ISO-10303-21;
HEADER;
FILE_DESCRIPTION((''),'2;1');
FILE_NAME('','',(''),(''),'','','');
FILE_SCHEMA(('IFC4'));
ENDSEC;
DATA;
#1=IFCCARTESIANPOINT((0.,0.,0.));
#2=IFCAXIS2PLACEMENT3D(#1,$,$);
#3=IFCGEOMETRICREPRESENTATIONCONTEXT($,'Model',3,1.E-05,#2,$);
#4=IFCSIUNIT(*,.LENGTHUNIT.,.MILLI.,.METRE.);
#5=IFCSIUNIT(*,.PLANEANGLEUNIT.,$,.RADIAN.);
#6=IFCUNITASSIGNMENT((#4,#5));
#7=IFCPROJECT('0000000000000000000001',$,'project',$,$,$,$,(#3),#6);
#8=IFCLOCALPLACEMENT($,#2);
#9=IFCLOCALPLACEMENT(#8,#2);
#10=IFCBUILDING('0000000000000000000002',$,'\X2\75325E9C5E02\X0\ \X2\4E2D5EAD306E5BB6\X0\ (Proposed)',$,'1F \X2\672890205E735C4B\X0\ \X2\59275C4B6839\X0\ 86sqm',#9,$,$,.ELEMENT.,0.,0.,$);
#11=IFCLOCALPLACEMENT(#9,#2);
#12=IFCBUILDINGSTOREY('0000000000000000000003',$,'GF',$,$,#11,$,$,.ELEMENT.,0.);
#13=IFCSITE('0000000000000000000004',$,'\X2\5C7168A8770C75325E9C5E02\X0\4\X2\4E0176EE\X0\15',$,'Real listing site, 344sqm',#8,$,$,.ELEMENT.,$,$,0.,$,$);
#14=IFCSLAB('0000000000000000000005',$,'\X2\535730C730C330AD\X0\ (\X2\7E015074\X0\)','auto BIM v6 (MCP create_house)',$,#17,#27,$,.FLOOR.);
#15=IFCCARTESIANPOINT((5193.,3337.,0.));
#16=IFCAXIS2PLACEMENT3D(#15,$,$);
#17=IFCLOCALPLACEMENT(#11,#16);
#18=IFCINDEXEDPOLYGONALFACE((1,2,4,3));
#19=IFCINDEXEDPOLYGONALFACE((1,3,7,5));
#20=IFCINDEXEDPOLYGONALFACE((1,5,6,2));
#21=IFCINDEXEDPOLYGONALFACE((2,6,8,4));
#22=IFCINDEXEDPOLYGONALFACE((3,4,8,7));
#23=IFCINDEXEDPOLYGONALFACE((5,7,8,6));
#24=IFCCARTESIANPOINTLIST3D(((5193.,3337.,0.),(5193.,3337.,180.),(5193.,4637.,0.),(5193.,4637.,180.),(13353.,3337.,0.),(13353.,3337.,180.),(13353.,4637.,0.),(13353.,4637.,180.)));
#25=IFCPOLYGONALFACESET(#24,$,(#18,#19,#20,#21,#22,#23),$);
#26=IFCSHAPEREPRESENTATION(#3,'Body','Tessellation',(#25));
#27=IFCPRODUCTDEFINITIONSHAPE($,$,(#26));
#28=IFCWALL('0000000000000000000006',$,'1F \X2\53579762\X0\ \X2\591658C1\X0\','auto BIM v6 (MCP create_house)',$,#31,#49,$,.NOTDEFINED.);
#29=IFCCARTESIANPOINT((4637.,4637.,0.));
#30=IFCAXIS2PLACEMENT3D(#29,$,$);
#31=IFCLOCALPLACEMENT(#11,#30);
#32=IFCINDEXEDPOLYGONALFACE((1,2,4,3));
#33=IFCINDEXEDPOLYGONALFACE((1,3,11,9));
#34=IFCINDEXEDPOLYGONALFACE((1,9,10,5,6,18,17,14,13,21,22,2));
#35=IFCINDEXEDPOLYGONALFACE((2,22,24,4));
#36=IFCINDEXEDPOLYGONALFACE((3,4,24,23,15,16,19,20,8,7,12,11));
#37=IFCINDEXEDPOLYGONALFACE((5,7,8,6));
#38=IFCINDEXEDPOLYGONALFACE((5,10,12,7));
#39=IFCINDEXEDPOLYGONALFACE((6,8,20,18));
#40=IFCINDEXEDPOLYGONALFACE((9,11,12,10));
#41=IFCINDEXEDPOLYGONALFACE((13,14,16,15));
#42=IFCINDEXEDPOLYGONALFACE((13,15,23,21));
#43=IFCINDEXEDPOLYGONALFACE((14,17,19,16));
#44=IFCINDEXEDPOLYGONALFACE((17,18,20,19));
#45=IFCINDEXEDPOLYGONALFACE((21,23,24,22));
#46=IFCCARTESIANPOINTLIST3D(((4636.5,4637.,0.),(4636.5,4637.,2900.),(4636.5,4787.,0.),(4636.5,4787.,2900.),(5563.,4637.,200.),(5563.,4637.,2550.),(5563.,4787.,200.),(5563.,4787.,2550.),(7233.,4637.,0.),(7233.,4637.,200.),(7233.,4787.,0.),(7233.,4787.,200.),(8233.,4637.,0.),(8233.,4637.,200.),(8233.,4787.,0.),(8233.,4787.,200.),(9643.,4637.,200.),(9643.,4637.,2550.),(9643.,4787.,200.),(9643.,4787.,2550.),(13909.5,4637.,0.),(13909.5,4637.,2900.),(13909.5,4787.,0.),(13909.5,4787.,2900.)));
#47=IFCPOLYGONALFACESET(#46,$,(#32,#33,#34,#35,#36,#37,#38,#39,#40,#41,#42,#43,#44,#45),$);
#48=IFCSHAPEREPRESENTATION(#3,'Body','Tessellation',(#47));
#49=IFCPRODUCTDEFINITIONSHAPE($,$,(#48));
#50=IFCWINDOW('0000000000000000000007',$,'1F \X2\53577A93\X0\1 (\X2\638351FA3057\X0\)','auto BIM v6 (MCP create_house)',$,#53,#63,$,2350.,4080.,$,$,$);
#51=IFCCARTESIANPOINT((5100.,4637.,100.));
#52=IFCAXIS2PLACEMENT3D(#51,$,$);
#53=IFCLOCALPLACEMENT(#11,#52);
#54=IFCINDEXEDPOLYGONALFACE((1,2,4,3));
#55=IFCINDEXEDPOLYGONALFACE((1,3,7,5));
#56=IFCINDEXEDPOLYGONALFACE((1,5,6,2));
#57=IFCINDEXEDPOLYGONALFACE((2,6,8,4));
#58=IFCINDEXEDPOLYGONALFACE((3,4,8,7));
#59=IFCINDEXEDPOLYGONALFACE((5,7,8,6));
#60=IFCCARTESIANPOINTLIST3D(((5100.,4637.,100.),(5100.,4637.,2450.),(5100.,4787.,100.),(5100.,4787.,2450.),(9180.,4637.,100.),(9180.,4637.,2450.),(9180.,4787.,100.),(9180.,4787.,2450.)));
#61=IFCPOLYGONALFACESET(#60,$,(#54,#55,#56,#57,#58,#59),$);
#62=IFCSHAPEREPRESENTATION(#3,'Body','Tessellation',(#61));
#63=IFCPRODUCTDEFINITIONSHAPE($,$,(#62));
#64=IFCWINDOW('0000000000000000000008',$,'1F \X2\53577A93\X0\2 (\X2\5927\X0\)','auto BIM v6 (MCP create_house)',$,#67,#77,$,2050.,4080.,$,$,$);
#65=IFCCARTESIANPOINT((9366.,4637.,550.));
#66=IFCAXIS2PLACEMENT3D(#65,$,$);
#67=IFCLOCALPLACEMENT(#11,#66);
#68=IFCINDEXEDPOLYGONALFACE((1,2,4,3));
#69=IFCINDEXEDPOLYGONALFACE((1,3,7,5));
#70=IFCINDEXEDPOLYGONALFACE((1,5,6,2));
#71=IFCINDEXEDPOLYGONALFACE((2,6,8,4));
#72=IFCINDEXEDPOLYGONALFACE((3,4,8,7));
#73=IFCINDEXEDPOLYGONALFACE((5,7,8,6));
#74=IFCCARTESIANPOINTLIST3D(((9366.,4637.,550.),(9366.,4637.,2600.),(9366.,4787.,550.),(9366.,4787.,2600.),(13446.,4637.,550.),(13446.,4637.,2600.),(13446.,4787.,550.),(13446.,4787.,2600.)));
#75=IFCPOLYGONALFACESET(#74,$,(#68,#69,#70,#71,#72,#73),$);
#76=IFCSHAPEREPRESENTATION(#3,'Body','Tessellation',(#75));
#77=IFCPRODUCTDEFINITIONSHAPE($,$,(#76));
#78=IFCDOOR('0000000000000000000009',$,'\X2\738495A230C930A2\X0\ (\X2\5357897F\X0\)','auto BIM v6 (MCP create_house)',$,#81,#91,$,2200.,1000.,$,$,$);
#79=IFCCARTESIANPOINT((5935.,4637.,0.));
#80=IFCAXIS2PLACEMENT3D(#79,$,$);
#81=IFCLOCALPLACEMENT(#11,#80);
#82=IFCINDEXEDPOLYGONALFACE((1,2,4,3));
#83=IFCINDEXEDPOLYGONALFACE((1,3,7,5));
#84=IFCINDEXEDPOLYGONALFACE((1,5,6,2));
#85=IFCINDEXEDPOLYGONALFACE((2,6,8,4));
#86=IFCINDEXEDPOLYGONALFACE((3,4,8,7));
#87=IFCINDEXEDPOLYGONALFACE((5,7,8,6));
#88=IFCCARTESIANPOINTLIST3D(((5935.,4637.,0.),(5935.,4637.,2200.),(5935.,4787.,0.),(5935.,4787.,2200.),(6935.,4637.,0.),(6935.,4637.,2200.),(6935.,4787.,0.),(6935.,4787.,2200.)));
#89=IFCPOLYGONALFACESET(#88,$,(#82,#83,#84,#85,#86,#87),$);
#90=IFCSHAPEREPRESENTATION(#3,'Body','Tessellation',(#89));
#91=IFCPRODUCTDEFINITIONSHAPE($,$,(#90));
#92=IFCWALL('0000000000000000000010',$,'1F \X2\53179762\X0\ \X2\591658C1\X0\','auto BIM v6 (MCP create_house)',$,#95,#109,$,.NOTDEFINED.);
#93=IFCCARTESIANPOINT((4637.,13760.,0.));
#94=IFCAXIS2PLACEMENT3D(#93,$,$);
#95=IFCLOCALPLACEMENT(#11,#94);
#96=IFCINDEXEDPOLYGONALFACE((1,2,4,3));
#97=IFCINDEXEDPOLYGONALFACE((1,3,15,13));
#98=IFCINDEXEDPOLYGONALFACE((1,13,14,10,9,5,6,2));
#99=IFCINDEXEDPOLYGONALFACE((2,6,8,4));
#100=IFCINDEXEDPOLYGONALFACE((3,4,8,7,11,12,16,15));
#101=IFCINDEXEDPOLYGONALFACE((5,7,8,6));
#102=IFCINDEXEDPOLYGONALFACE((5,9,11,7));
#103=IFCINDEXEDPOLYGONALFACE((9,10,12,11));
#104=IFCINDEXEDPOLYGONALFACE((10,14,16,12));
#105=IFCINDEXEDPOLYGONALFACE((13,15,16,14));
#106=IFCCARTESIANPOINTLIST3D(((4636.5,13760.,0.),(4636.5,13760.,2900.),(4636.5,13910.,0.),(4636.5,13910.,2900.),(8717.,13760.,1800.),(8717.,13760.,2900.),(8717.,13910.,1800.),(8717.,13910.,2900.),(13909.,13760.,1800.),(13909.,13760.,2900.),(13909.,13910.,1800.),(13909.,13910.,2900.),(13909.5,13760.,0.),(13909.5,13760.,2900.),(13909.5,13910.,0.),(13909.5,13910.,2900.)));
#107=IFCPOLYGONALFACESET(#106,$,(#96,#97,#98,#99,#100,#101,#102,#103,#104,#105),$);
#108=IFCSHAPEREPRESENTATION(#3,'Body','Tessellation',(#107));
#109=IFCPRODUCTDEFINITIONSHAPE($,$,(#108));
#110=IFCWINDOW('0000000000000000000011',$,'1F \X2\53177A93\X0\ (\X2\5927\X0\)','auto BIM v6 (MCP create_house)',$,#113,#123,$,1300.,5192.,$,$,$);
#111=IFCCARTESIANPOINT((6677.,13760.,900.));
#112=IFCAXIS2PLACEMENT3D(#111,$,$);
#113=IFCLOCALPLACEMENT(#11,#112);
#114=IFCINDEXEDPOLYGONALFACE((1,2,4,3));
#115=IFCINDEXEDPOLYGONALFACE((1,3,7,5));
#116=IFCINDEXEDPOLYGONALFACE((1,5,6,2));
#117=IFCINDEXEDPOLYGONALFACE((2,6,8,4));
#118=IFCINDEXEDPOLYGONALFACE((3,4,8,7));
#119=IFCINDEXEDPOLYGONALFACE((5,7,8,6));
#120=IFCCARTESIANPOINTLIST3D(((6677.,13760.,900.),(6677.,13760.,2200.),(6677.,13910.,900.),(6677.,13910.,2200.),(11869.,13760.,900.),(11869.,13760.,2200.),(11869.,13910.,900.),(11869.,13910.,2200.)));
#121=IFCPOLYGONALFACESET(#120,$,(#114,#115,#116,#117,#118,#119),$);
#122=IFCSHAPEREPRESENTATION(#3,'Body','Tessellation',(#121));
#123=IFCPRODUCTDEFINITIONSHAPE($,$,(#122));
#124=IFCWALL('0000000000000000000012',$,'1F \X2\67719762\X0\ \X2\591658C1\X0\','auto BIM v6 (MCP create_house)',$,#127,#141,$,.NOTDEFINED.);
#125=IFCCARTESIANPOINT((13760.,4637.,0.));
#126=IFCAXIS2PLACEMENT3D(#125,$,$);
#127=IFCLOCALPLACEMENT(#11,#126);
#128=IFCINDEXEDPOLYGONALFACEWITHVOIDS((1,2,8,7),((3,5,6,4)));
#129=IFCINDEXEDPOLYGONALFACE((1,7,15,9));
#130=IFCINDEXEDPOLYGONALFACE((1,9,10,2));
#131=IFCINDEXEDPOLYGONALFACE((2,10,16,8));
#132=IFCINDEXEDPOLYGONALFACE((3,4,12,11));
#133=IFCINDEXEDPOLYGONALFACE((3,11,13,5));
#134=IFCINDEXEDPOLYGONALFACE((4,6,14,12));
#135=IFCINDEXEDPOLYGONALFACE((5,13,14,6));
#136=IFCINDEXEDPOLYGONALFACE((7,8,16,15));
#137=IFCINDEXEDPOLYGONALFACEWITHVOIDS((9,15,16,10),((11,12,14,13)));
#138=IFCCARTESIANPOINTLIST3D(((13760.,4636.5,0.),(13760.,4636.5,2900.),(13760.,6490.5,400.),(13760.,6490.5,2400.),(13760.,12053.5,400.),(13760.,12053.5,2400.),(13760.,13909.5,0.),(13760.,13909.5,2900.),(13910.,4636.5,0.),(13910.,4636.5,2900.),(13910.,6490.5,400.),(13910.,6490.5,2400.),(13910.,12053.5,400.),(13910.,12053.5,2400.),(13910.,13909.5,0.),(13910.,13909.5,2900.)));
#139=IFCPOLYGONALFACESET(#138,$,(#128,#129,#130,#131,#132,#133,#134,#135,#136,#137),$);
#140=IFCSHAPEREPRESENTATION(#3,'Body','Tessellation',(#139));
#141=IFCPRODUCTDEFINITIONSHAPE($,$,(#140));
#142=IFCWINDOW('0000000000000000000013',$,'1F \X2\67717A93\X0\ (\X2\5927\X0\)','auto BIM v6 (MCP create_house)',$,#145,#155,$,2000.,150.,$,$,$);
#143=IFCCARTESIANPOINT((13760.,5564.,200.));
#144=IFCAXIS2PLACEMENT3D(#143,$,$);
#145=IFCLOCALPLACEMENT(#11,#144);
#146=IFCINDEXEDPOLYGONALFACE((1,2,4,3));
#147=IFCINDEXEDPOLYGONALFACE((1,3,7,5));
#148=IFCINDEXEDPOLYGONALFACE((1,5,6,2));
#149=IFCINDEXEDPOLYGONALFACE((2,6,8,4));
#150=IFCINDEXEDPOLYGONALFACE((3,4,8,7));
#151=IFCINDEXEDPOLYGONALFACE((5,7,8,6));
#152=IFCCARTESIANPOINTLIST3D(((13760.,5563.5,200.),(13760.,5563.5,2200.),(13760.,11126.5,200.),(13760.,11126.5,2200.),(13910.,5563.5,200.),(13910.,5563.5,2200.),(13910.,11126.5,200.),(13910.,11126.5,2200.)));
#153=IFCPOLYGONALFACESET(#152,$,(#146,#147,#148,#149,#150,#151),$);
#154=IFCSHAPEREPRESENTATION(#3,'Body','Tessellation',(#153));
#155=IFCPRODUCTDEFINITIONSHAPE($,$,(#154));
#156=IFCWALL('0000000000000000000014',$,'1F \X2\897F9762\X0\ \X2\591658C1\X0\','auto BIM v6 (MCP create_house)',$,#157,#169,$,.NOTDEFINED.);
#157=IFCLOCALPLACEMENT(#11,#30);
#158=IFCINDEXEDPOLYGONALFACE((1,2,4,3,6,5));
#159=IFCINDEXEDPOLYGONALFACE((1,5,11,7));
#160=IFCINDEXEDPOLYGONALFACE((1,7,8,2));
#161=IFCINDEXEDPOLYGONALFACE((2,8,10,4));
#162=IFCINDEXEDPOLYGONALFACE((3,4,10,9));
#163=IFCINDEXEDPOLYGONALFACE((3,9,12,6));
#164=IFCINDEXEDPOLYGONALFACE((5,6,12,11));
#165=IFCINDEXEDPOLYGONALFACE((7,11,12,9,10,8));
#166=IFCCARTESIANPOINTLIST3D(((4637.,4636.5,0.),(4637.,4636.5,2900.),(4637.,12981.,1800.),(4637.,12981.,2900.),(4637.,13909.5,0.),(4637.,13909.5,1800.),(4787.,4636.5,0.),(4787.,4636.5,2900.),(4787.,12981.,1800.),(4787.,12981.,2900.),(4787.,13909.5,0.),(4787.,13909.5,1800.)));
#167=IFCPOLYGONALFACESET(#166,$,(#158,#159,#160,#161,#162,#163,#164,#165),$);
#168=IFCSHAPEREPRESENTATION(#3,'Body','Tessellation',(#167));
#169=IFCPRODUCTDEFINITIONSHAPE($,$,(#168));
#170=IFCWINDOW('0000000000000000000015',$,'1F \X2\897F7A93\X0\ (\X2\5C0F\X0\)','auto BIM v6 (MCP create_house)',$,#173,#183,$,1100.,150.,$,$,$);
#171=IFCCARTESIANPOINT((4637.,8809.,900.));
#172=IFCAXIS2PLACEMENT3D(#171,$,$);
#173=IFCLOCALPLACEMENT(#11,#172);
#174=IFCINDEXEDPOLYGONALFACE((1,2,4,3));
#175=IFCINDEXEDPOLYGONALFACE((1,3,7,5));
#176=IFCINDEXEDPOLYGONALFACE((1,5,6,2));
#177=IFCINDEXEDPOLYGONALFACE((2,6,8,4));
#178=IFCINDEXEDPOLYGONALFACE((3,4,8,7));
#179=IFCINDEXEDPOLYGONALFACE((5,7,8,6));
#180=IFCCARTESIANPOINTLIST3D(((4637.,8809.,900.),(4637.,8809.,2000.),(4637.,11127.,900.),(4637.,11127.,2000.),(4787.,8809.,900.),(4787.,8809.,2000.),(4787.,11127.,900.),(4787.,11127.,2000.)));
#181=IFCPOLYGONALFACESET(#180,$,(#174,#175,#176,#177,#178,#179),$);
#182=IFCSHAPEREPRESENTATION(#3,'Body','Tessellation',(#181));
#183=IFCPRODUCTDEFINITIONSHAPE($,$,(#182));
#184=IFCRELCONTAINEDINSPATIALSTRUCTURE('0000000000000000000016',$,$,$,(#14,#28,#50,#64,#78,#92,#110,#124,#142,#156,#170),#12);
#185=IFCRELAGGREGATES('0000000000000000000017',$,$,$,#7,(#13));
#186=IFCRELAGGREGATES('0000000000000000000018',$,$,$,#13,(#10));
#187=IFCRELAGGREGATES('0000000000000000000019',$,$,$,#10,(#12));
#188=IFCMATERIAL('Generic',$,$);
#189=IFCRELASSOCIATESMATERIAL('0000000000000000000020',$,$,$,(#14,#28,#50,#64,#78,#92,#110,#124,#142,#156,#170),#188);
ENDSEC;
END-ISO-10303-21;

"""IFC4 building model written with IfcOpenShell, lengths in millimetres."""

from ifc_helpers import new_model, si_unit, frame, frame_2d, origin, place, context, project, spatial, rectangle, extrude, material, element, fill, save


model = new_model("IFC4")

# Units and contexts
model_context = context("Model", 3, precision=1e-05, world=origin())
ifc_project = project(units=[si_unit("LENGTHUNIT", "METRE", prefix="MILLI"), si_unit("PLANEANGLEUNIT", "RADIAN")], contexts=[model_context])

# Site, building, storey
site_placement = place(None, origin())
site = spatial("IfcSite", under=ifc_project, at=site_placement, Name="山梨県甲府市4丁目15", ObjectType="Real listing site, 344sqm", CompositionType="ELEMENT", RefElevation=0.0)
building_placement = place(site_placement, origin())
building = spatial("IfcBuilding", under=site, at=building_placement, Name="甲府市 中庭の家 (Proposed)", ObjectType="1F 木造平屋 大屋根 86sqm", CompositionType="ELEMENT", ElevationOfRefHeight=0.0, ElevationOfTerrain=0.0)
storey_placement = place(building_placement, origin())
storey = spatial("IfcBuildingStorey", under=building, at=storey_placement, Name="GF", CompositionType="ELEMENT", Elevation=0.0)

# Slab
ifc_material = material(Name="Generic")
slab_1_placement = place(storey_placement, frame((5193.0, 3337.0, 0.0)))
element("IfcSlab", 1, at=slab_1_placement, inside=storey, material=ifc_material, Name="南デッキ (縁側)", Description="auto BIM v6 (MCP create_house)", PredefinedType="FLOOR", context=model_context, shape_type="SweptSolid", body=[
    extrude(rectangle(XDim=8160.0, YDim=1300.0, at=frame_2d((4080.0, 650.0))), frame((5193.0, 3337.0, 0.0)), (0.0, 0.0, 1.0), 180.0),
])

# Wall, openings, windows, door
wall_1_placement = place(storey_placement, frame((4637.0, 4637.0, 0.0)))
wall_1 = element("IfcWall", 2, at=wall_1_placement, inside=storey, material=ifc_material, Name="1F 南面 外壁", Description="auto BIM v6 (MCP create_house)", PredefinedType="NOTDEFINED", context=model_context, shape_type="SweptSolid", body=[
    extrude(rectangle(XDim=9273.0, YDim=150.0, at=frame_2d((4636.0, 75.0))), frame((4637.0, 4637.0, 0.0)), (0.0, 0.0, 1.0), 2900.0),
])
opening_1_placement = place(storey_placement, frame((5100.0, 4637.0, 100.0)))
opening_1 = element("IfcOpeningElement", 3, at=opening_1_placement, cuts=wall_1, PredefinedType="NOTDEFINED", context=model_context, shape_type="SweptSolid", body=[
    extrude(rectangle(XDim=4080.0, YDim=150.0, at=frame_2d((2040.0, 75.0))), frame((5100.0, 4637.0, 100.0)), (0.0, 0.0, 1.0), 2350.0),
])
opening_2_placement = place(storey_placement, frame((9366.0, 4637.0, 550.0)))
opening_2 = element("IfcOpeningElement", 4, at=opening_2_placement, cuts=wall_1, PredefinedType="NOTDEFINED", context=model_context, shape_type="SweptSolid", body=[
    extrude(rectangle(XDim=4080.0, YDim=150.0, at=frame_2d((2040.0, 75.0))), frame((9366.0, 4637.0, 550.0)), (0.0, 0.0, 1.0), 2050.0),
])
opening_3_placement = place(storey_placement, frame((5935.0, 4637.0, 0.0)))
opening_3 = element("IfcOpeningElement", 5, at=opening_3_placement, cuts=wall_1, PredefinedType="NOTDEFINED", context=model_context, shape_type="SweptSolid", body=[
    extrude(rectangle(XDim=1000.0, YDim=150.0, at=frame_2d((500.0, 75.0))), frame((5935.0, 4637.0, 0.0)), (0.0, 0.0, 1.0), 2200.0),
])
window_1_placement = place(storey_placement, frame((5100.0, 4637.0, 100.0)))
window_1 = element("IfcWindow", 6, at=window_1_placement, inside=storey, material=ifc_material, Name="1F 南窓1 (掃出し)", Description="auto BIM v6 (MCP create_house)", OverallHeight=2350.0, OverallWidth=4080.0, context=model_context, shape_type="SweptSolid", body=[
    extrude(rectangle(XDim=4080.0, YDim=150.0, at=frame_2d((2040.0, 75.0))), frame((5100.0, 4637.0, 100.0)), (0.0, 0.0, 1.0), 2350.0),
])
fill(opening_1, window_1)
window_2_placement = place(storey_placement, frame((9366.0, 4637.0, 550.0)))
window_2 = element("IfcWindow", 7, at=window_2_placement, inside=storey, material=ifc_material, Name="1F 南窓2 (大)", Description="auto BIM v6 (MCP create_house)", OverallHeight=2050.0, OverallWidth=4080.0, context=model_context, shape_type="SweptSolid", body=[
    extrude(rectangle(XDim=4080.0, YDim=150.0, at=frame_2d((2040.0, 75.0))), frame((9366.0, 4637.0, 550.0)), (0.0, 0.0, 1.0), 2050.0),
])
fill(opening_2, window_2)
door_placement = place(storey_placement, frame((5935.0, 4637.0, 0.0)))
door = element("IfcDoor", 8, at=door_placement, inside=storey, material=ifc_material, Name="玄関ドア (南西)", Description="auto BIM v6 (MCP create_house)", OverallHeight=2200.0, OverallWidth=1000.0, context=model_context, shape_type="SweptSolid", body=[
    extrude(rectangle(XDim=1000.0, YDim=150.0, at=frame_2d((500.0, 75.0))), frame((5935.0, 4637.0, 0.0)), (0.0, 0.0, 1.0), 2200.0),
])
fill(opening_3, door)

# Walls, openings, windows
wall_2_placement = place(storey_placement, frame((4637.0, 13760.0, 0.0)))
wall_2 = element("IfcWall", 9, at=wall_2_placement, inside=storey, material=ifc_material, Name="1F 北面 外壁", Description="auto BIM v6 (MCP create_house)", PredefinedType="NOTDEFINED", context=model_context, shape_type="SweptSolid", body=[
    extrude(rectangle(XDim=9273.0, YDim=150.0, at=frame_2d((4636.0, 75.0))), frame((4637.0, 13760.0, 0.0)), (0.0, 0.0, 1.0), 2900.0),
])
opening_4_placement = place(storey_placement, frame((6677.0, 13760.0, 900.0)))
opening_4 = element("IfcOpeningElement", 10, at=opening_4_placement, cuts=wall_2, PredefinedType="NOTDEFINED", context=model_context, shape_type="SweptSolid", body=[
    extrude(rectangle(XDim=5192.0, YDim=150.0, at=frame_2d((2596.0, 75.0))), frame((6677.0, 13760.0, 900.0)), (0.0, 0.0, 1.0), 1300.0),
])
window_3_placement = place(storey_placement, frame((6677.0, 13760.0, 900.0)))
window_3 = element("IfcWindow", 11, at=window_3_placement, inside=storey, material=ifc_material, Name="1F 北窓 (大)", Description="auto BIM v6 (MCP create_house)", OverallHeight=1300.0, OverallWidth=5192.0, context=model_context, shape_type="SweptSolid", body=[
    extrude(rectangle(XDim=5192.0, YDim=150.0, at=frame_2d((2596.0, 75.0))), frame((6677.0, 13760.0, 900.0)), (0.0, 0.0, 1.0), 1300.0),
])
fill(opening_4, window_3)
wall_3_placement = place(storey_placement, frame((13760.0, 4637.0, 0.0)))
wall_3 = element("IfcWall", 12, at=wall_3_placement, inside=storey, material=ifc_material, Name="1F 東面 外壁", Description="auto BIM v6 (MCP create_house)", PredefinedType="NOTDEFINED", context=model_context, shape_type="SweptSolid", body=[
    extrude(rectangle(XDim=150.0, YDim=9273.0, at=frame_2d((75.0, 4636.0))), frame((13760.0, 4637.0, 0.0)), (0.0, 0.0, 1.0), 2900.0),
])
opening_5_placement = place(storey_placement, frame((13760.0, 5564.0, 200.0)))
opening_5 = element("IfcOpeningElement", 13, at=opening_5_placement, cuts=wall_3, PredefinedType="NOTDEFINED", context=model_context, shape_type="SweptSolid", body=[
    extrude(rectangle(XDim=150.0, YDim=5563.0, at=frame_2d((75.0, 2781.0))), frame((13760.0, 5564.0, 200.0)), (0.0, 0.0, 1.0), 2000.0),
])
window_4_placement = place(storey_placement, frame((13760.0, 5564.0, 200.0)))
window_4 = element("IfcWindow", 14, at=window_4_placement, inside=storey, material=ifc_material, Name="1F 東窓 (大)", Description="auto BIM v6 (MCP create_house)", OverallHeight=2000.0, OverallWidth=150.0, context=model_context, shape_type="SweptSolid", body=[
    extrude(rectangle(XDim=150.0, YDim=5563.0, at=frame_2d((75.0, 2781.0))), frame((13760.0, 5564.0, 200.0)), (0.0, 0.0, 1.0), 2000.0),
])
fill(opening_5, window_4)
wall_4_placement = place(storey_placement, frame((4637.0, 4637.0, 0.0)))
wall_4 = element("IfcWall", 15, at=wall_4_placement, inside=storey, material=ifc_material, Name="1F 西面 外壁", Description="auto BIM v6 (MCP create_house)", PredefinedType="NOTDEFINED", context=model_context, shape_type="SweptSolid", body=[
    extrude(rectangle(XDim=150.0, YDim=9273.0, at=frame_2d((75.0, 4636.0))), frame((4637.0, 4637.0, 0.0)), (0.0, 0.0, 1.0), 2900.0),
])
opening_6_placement = place(storey_placement, frame((4637.0, 8809.0, 900.0)))
opening_6 = element("IfcOpeningElement", 16, at=opening_6_placement, cuts=wall_4, PredefinedType="NOTDEFINED", context=model_context, shape_type="SweptSolid", body=[
    extrude(rectangle(XDim=150.0, YDim=2318.0, at=frame_2d((75.0, 1159.0))), frame((4637.0, 8809.0, 900.0)), (0.0, 0.0, 1.0), 1100.0),
])
window_5_placement = place(storey_placement, frame((4637.0, 8809.0, 900.0)))
window_5 = element("IfcWindow", 17, at=window_5_placement, inside=storey, material=ifc_material, Name="1F 西窓 (小)", Description="auto BIM v6 (MCP create_house)", OverallHeight=1100.0, OverallWidth=150.0, context=model_context, shape_type="SweptSolid", body=[
    extrude(rectangle(XDim=150.0, YDim=2318.0, at=frame_2d((75.0, 1159.0))), frame((4637.0, 8809.0, 900.0)), (0.0, 0.0, 1.0), 1100.0),
])
fill(opening_6, window_5)

save(model, "model.ifc")
